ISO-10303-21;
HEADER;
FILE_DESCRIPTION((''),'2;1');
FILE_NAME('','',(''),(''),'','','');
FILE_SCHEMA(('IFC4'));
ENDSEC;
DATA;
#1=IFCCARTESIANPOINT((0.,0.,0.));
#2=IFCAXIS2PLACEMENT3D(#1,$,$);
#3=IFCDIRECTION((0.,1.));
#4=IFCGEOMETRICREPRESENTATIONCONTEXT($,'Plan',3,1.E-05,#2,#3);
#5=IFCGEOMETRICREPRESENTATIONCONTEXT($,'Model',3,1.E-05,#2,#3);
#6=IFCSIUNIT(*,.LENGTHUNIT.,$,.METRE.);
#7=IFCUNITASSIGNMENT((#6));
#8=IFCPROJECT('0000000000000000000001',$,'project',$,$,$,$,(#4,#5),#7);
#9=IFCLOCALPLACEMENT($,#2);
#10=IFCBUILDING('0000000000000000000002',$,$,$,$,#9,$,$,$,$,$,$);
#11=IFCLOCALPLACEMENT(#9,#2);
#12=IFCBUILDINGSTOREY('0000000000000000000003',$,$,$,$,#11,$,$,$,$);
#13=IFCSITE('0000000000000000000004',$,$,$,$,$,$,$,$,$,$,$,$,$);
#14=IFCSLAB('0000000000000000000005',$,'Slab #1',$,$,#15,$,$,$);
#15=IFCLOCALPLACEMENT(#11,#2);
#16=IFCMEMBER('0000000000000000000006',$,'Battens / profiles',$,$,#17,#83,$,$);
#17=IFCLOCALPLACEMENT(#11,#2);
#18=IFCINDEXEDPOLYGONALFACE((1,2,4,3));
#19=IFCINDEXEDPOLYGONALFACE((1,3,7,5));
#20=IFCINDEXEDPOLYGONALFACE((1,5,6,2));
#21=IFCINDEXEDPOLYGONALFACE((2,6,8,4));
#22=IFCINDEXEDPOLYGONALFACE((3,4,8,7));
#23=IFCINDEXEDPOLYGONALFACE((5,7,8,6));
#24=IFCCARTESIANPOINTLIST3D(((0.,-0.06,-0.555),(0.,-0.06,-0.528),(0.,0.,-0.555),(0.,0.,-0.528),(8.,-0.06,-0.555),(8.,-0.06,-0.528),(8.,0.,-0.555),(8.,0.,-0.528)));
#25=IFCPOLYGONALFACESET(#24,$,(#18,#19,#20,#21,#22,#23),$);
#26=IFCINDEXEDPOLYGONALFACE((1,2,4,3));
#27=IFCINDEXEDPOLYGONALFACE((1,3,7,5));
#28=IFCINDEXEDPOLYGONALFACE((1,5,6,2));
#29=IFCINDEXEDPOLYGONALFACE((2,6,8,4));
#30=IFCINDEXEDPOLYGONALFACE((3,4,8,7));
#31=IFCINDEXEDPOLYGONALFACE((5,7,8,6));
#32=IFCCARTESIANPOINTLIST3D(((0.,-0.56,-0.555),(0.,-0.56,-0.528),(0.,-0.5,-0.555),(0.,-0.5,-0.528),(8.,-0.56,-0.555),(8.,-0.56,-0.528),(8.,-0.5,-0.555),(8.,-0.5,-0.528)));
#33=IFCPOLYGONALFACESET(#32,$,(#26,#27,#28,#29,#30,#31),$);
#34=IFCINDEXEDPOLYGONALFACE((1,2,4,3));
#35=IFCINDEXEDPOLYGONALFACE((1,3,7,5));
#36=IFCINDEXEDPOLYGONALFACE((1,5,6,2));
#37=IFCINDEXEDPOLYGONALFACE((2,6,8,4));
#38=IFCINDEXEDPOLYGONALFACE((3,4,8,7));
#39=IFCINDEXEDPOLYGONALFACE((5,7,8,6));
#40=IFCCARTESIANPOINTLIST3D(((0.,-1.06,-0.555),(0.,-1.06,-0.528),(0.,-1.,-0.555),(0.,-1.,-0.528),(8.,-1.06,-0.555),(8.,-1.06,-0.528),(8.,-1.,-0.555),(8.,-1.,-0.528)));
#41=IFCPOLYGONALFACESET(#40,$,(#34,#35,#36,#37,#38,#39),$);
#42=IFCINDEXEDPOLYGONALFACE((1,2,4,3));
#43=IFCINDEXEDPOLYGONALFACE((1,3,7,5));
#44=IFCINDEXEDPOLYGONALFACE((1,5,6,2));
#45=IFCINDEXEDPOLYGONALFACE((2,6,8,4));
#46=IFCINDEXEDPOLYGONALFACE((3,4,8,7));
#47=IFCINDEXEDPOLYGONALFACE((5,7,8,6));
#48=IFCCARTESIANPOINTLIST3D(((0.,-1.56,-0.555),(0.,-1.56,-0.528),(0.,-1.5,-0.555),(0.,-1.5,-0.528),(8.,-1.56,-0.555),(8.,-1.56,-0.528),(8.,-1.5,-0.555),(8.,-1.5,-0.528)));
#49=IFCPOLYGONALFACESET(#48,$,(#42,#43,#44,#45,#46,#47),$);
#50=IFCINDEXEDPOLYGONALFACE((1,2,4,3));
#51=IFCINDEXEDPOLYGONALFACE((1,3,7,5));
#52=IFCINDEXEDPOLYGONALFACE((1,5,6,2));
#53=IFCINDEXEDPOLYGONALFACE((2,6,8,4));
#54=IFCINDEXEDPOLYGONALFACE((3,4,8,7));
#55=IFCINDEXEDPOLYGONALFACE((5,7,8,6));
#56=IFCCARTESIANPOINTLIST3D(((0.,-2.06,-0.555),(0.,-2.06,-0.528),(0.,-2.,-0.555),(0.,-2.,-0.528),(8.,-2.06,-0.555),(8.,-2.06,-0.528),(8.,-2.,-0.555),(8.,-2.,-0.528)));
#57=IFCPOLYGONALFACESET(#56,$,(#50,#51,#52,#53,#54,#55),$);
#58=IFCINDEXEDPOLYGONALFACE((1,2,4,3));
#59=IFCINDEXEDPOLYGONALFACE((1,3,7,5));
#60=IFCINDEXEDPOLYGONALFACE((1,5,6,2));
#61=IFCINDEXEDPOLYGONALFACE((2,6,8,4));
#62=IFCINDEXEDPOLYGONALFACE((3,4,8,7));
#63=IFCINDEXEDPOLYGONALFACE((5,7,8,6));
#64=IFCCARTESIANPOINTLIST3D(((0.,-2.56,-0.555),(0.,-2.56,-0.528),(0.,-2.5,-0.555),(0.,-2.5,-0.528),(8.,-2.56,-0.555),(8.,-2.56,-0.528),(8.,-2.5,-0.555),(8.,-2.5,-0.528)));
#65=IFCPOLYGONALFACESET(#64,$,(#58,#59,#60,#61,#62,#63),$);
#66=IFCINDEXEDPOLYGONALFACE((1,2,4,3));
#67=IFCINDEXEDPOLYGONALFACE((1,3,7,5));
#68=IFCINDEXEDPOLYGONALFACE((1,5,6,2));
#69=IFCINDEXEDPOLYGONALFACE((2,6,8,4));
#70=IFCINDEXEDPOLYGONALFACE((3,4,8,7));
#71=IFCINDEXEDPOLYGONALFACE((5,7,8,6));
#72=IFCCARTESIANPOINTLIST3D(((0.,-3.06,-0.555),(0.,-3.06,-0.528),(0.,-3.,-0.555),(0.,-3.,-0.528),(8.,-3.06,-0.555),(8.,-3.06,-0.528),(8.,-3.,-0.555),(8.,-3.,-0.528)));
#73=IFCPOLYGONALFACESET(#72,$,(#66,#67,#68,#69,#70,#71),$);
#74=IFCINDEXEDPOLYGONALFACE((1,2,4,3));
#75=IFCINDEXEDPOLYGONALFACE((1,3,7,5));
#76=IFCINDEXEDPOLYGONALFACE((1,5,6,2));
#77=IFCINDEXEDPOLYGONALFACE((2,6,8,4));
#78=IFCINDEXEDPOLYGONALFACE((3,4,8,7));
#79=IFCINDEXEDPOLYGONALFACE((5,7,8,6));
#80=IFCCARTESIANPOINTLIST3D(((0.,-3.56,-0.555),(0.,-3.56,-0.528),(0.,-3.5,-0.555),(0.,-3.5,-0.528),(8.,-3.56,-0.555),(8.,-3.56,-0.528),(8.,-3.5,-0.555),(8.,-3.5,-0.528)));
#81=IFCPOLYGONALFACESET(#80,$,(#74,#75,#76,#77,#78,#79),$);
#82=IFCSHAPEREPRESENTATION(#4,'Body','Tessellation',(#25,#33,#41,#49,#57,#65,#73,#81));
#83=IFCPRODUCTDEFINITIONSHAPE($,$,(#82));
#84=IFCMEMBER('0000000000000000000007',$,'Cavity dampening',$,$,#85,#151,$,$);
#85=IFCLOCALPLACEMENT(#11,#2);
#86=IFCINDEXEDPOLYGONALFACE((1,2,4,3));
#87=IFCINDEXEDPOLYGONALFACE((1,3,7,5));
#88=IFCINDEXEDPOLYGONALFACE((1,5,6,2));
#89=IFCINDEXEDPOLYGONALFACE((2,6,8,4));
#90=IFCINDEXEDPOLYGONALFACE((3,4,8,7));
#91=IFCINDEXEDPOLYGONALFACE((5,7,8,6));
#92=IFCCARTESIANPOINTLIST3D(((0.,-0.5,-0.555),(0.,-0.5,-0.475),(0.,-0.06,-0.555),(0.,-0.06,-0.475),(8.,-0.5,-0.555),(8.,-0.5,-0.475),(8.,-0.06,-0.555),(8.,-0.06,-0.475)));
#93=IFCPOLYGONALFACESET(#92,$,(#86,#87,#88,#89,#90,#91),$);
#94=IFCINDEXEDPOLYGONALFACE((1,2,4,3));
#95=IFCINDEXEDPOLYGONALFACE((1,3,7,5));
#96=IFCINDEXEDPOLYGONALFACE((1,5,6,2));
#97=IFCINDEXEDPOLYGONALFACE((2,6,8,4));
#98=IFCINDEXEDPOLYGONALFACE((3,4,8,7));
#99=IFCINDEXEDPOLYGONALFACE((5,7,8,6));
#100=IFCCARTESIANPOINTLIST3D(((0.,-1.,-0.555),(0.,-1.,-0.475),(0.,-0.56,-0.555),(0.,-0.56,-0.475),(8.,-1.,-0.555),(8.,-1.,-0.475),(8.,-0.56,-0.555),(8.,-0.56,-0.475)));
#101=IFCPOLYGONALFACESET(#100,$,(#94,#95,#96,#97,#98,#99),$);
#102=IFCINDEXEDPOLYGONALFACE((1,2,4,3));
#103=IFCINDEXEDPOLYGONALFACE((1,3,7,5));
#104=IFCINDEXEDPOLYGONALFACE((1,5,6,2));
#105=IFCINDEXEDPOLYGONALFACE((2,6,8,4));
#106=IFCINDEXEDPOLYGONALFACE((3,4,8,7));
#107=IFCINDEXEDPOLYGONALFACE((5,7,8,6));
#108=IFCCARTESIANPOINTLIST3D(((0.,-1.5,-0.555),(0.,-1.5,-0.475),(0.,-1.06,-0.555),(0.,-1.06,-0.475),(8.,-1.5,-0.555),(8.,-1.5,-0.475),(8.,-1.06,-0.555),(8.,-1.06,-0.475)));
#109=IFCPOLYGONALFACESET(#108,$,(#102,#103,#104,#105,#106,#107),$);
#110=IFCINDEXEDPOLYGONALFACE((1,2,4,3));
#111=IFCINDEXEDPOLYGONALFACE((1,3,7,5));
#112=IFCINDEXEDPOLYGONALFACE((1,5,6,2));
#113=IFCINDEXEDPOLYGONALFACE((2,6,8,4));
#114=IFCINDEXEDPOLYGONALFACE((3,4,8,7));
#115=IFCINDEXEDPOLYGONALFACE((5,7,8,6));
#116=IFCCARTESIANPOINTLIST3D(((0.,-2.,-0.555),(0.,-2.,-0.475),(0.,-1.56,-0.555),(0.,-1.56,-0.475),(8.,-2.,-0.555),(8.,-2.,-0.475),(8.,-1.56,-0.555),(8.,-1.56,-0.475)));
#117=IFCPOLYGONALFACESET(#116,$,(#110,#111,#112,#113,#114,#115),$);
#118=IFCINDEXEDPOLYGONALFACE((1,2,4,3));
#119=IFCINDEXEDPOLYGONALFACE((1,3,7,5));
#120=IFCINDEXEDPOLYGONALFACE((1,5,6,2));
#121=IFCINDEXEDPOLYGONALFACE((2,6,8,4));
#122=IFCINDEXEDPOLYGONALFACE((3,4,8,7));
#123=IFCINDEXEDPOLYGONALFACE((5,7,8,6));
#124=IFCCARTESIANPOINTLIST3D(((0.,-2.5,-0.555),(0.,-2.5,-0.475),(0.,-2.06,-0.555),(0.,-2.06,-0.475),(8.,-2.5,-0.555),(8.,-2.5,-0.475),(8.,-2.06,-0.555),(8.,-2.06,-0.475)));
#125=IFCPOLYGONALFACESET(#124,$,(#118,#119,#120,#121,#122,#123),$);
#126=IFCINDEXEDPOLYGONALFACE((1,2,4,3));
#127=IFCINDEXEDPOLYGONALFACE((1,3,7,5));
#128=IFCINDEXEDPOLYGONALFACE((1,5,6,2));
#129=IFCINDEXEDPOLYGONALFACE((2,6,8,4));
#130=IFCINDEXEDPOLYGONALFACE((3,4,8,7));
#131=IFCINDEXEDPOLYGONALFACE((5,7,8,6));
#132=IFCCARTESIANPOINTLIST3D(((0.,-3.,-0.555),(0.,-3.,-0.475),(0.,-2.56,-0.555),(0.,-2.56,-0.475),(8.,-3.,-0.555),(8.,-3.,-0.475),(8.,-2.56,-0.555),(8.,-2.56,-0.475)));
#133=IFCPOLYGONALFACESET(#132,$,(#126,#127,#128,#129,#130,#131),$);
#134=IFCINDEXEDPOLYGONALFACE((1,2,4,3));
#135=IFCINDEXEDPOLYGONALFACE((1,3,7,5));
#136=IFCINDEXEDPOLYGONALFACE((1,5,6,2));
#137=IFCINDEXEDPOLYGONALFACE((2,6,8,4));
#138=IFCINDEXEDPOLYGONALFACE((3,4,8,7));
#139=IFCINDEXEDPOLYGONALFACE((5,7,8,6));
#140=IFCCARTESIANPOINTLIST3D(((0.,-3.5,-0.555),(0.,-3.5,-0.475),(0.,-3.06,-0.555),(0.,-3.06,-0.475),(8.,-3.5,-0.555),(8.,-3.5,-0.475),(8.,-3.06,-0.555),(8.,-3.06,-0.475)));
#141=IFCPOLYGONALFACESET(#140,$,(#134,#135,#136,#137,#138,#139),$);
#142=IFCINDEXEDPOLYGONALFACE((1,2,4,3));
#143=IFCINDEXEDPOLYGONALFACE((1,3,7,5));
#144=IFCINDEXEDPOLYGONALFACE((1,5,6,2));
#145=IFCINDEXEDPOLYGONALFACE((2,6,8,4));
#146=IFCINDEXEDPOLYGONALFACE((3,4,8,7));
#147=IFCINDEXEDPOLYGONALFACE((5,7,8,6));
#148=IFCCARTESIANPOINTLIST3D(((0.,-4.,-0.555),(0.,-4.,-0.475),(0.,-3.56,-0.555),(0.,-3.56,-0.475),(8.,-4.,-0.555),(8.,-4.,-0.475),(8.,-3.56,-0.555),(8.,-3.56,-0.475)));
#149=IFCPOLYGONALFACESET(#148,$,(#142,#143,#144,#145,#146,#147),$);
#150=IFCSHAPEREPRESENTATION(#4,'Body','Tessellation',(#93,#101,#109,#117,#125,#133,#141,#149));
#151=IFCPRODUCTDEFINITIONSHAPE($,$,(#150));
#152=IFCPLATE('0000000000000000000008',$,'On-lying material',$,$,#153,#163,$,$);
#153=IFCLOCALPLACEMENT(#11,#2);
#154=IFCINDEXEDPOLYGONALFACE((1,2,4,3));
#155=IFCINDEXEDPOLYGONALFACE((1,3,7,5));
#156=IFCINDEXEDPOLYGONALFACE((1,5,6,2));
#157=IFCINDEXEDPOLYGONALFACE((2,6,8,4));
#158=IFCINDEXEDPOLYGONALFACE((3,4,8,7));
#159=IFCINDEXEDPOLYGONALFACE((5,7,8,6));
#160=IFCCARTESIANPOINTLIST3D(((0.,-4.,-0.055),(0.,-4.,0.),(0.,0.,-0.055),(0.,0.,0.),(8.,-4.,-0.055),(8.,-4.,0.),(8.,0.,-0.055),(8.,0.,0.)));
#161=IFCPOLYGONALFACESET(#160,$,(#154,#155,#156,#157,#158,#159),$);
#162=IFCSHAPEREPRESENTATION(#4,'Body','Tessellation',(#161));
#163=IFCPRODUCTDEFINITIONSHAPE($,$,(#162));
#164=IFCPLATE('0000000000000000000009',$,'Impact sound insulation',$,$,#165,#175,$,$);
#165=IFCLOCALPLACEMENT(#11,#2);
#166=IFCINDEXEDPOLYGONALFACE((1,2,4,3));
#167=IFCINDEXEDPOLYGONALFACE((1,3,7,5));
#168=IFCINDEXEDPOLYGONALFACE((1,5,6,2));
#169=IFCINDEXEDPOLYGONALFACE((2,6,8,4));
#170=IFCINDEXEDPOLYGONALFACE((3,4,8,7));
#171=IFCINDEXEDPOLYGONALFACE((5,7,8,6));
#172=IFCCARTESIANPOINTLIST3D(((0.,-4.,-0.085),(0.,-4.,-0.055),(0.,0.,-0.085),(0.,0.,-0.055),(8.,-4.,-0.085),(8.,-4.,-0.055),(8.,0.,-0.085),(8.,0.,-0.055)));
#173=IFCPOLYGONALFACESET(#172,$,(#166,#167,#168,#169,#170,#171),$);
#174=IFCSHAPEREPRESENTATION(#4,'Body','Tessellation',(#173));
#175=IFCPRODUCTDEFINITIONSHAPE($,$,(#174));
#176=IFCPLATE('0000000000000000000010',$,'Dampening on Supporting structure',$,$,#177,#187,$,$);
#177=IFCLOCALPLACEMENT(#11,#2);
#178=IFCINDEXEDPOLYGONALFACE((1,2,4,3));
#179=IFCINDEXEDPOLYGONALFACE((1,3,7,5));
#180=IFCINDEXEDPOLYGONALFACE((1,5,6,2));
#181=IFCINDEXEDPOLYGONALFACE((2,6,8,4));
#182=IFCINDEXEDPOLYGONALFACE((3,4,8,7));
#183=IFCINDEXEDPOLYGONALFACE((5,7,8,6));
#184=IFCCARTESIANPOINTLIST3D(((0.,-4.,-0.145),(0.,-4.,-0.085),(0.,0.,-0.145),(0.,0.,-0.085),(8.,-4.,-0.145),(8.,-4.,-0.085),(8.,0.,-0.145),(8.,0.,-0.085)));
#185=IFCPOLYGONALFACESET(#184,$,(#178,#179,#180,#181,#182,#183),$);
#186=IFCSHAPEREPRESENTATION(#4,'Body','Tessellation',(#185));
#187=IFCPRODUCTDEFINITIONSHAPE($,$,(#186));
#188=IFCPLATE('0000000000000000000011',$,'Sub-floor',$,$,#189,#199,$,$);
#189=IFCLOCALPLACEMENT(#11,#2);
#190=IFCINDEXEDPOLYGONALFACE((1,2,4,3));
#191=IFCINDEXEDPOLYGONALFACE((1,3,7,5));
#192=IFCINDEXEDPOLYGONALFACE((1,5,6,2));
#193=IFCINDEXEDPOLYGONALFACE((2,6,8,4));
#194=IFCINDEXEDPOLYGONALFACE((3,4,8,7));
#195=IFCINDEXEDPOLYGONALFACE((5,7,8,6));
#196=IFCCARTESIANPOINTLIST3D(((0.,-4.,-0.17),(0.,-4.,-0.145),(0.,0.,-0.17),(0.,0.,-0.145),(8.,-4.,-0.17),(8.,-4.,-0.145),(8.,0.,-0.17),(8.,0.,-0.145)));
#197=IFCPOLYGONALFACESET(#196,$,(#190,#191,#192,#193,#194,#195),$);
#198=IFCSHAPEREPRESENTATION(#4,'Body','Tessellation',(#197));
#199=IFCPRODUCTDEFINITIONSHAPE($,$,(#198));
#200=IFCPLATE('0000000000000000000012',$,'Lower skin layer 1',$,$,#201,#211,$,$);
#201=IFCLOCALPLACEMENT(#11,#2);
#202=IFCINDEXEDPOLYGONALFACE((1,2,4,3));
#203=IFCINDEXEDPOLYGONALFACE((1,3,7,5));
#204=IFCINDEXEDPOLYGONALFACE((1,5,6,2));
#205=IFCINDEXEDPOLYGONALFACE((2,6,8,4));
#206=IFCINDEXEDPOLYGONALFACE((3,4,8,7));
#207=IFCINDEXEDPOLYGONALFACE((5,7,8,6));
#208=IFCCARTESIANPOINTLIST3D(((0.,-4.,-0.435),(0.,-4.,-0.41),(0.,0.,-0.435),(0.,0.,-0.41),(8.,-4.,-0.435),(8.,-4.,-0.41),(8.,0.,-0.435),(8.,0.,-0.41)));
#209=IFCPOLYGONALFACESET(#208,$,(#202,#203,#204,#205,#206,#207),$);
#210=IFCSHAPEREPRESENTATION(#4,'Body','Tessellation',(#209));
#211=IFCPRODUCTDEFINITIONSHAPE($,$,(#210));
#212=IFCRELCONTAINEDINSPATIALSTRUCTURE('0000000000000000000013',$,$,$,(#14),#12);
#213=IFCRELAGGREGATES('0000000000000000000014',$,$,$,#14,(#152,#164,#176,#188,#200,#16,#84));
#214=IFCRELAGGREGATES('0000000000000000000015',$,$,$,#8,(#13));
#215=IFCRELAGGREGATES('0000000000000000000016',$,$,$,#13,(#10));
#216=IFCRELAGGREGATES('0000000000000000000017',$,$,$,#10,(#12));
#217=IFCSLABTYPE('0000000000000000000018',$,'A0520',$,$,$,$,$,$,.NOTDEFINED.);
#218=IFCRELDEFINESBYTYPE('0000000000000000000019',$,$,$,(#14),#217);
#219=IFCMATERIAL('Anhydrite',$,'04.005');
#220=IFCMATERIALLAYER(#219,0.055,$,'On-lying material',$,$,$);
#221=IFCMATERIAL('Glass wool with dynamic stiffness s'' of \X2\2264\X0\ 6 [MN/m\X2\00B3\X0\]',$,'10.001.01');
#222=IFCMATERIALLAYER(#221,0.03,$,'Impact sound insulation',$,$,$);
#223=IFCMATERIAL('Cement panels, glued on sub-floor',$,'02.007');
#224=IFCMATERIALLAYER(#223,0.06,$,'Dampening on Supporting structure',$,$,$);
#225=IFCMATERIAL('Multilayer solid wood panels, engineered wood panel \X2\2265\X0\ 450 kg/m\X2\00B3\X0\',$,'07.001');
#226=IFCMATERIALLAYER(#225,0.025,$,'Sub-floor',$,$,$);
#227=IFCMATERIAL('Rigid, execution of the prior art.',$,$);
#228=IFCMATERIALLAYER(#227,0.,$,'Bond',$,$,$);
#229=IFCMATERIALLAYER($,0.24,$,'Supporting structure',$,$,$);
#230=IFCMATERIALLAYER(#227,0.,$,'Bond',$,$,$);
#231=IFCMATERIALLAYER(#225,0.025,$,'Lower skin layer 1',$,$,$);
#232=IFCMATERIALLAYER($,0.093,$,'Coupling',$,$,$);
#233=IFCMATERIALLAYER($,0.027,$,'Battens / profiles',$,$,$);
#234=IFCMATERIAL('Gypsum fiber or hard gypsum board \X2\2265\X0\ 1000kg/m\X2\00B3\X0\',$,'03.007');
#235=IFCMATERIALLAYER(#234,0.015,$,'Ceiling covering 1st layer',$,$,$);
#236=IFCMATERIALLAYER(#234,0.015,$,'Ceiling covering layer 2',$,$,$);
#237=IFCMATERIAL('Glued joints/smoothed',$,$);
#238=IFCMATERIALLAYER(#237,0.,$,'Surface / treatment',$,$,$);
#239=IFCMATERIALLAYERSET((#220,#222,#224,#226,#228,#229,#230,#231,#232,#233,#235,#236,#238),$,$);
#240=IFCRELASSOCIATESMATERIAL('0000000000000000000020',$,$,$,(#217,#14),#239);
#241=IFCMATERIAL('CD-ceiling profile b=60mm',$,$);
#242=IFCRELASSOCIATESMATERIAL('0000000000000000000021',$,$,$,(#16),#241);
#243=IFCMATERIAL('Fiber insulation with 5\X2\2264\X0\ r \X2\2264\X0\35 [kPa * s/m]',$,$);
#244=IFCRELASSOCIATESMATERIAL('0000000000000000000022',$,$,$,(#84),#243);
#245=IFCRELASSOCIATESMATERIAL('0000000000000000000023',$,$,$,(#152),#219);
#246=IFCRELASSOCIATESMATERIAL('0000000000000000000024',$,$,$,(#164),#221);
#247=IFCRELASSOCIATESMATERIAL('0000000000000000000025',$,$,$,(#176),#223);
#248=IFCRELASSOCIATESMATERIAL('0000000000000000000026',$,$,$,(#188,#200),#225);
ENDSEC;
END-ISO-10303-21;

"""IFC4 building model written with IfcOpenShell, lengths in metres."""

from ifc_helpers import new_model, si_unit, direction, frame, frame_2d, origin, origin_with_axes, place, context, project, spatial, rectangle, extrude, material, layer, layer_set, type_object, element, aggregate, save


model = new_model("IFC4")

# Units and contexts
plan_context = context("Plan", 3, precision=1e-05, world=origin(), true_north=direction((0.0, 1.0)))
model_context = context("Model", 3, precision=1e-05, world=origin(), true_north=direction((0.0, 1.0)))
ifc_project = project(units=[si_unit("LENGTHUNIT", "METRE")], contexts=[plan_context, model_context])

# Site, building, storey
site = spatial("IfcSite", under=ifc_project)
building_placement = place(None, origin())
building = spatial("IfcBuilding", under=site, at=building_placement)
storey_placement = place(building_placement, origin())
storey = spatial("IfcBuildingStorey", under=building, at=storey_placement)

# Slab, members, plates
ifc_material_1 = material(Name="Anhydrite", Category="04.005")
ifc_layer_1 = layer(ifc_material_1, 0.055, Name="On-lying material")
ifc_material_2 = material(Name="Glass wool with dynamic stiffness s' of ≤ 6 [MN/m³]", Category="10.001.01")
ifc_layer_2 = layer(ifc_material_2, 0.03, Name="Impact sound insulation")
ifc_material_3 = material(Name="Cement panels, glued on sub-floor", Category="02.007")
ifc_layer_3 = layer(ifc_material_3, 0.06, Name="Dampening on Supporting structure")
ifc_material_4 = material(Name="Multilayer solid wood panels, engineered wood panel ≥ 450 kg/m³", Category="07.001")
ifc_layer_4 = layer(ifc_material_4, 0.025, Name="Sub-floor")
ifc_material_5 = material(Name="Rigid, execution of the prior art.")
ifc_layer_5 = layer(ifc_material_5, 0.0, Name="Bond")
ifc_layer_6 = layer(None, 0.24, Name="Supporting structure")
ifc_layer_7 = layer(ifc_material_5, 0.0, Name="Bond")
ifc_layer_8 = layer(ifc_material_4, 0.025, Name="Lower skin layer 1")
ifc_layer_9 = layer(None, 0.093, Name="Coupling")
ifc_layer_10 = layer(None, 0.027, Name="Battens / profiles")
ifc_material_6 = material(Name="Gypsum fiber or hard gypsum board ≥ 1000kg/m³", Category="03.007")
ifc_layer_11 = layer(ifc_material_6, 0.015, Name="Ceiling covering 1st layer")
ifc_layer_12 = layer(ifc_material_6, 0.015, Name="Ceiling covering layer 2")
ifc_material_7 = material(Name="Glued joints/smoothed")
ifc_layer_13 = layer(ifc_material_7, 0.0, Name="Surface / treatment")
ifc_layer_set = layer_set([ifc_layer_1, ifc_layer_2, ifc_layer_3, ifc_layer_4, ifc_layer_5, ifc_layer_6, ifc_layer_7, ifc_layer_8, ifc_layer_9, ifc_layer_10, ifc_layer_11, ifc_layer_12, ifc_layer_13])
slab_type = type_object("IfcSlabType", Name="A0520", PredefinedType="NOTDEFINED", material=ifc_layer_set)
slab_placement = place(None, frame((0.0, 0.0, 0.0), z_axis=(0.0, 0.0, -1.0), x_axis=(1.0, 0.0, 0.0)))
slab = element("IfcSlab", 1, at=slab_placement, inside=storey, type_object=slab_type, material=ifc_layer_set, Name="Slab #1")
ifc_material_8 = material(Name="Fiber insulation with 5≤ r ≤35 [kPa * s/m]")
ifc_material_9 = material(Name="CD-ceiling profile b=60mm")
member_1_placement = place(slab_placement, origin())
member_1 = element("IfcMember", 2, at=member_1_placement, material=ifc_material_9, Name="Battens / profiles", context=plan_context, shape_type="SweptSolid", body=[
    extrude(rectangle(XDim=0.06, YDim=0.027, at=frame_2d((0.03, 0.0135), x_axis=(1.0, 0.0))), frame((0.0, 0.0, 0.528), z_axis=(1.0, 0.0, 0.0), x_axis=(0.0, 1.0, 0.0)), (0.0, 0.0, 1.0), 8.0),
    extrude(rectangle(XDim=0.06, YDim=0.027, at=frame_2d((0.03, 0.0135), x_axis=(1.0, 0.0))), frame((0.0, 0.5, 0.528), z_axis=(1.0, 0.0, 0.0), x_axis=(0.0, 1.0, 0.0)), (0.0, 0.0, 1.0), 8.0),
    extrude(rectangle(XDim=0.06, YDim=0.027, at=frame_2d((0.03, 0.0135), x_axis=(1.0, 0.0))), frame((0.0, 1.0, 0.528), z_axis=(1.0, 0.0, 0.0), x_axis=(0.0, 1.0, 0.0)), (0.0, 0.0, 1.0), 8.0),
    extrude(rectangle(XDim=0.06, YDim=0.027, at=frame_2d((0.03, 0.0135), x_axis=(1.0, 0.0))), frame((0.0, 1.5, 0.528), z_axis=(1.0, 0.0, 0.0), x_axis=(0.0, 1.0, 0.0)), (0.0, 0.0, 1.0), 8.0),
    extrude(rectangle(XDim=0.06, YDim=0.027, at=frame_2d((0.03, 0.0135), x_axis=(1.0, 0.0))), frame((0.0, 2.0, 0.528), z_axis=(1.0, 0.0, 0.0), x_axis=(0.0, 1.0, 0.0)), (0.0, 0.0, 1.0), 8.0),
    extrude(rectangle(XDim=0.06, YDim=0.027, at=frame_2d((0.03, 0.0135), x_axis=(1.0, 0.0))), frame((0.0, 2.5, 0.528), z_axis=(1.0, 0.0, 0.0), x_axis=(0.0, 1.0, 0.0)), (0.0, 0.0, 1.0), 8.0),
    extrude(rectangle(XDim=0.06, YDim=0.027, at=frame_2d((0.03, 0.0135), x_axis=(1.0, 0.0))), frame((0.0, 3.0, 0.528), z_axis=(1.0, 0.0, 0.0), x_axis=(0.0, 1.0, 0.0)), (0.0, 0.0, 1.0), 8.0),
    extrude(rectangle(XDim=0.06, YDim=0.027, at=frame_2d((0.03, 0.0135), x_axis=(1.0, 0.0))), frame((0.0, 3.5, 0.528), z_axis=(1.0, 0.0, 0.0), x_axis=(0.0, 1.0, 0.0)), (0.0, 0.0, 1.0), 8.0),
])
member_2_placement = place(slab_placement, origin())
member_2 = element("IfcMember", 3, at=member_2_placement, material=ifc_material_8, Name="Cavity dampening", context=plan_context, shape_type="SweptSolid", body=[
    extrude(rectangle(XDim=0.44, YDim=0.08, at=frame_2d((0.22, 0.04), x_axis=(1.0, 0.0))), frame((0.0, 0.06, 0.475), z_axis=(1.0, 0.0, 0.0), x_axis=(0.0, 1.0, 0.0)), (0.0, 0.0, 1.0), 8.0),
    extrude(rectangle(XDim=0.44, YDim=0.08, at=frame_2d((0.22, 0.04), x_axis=(1.0, 0.0))), frame((0.0, 0.56, 0.475), z_axis=(1.0, 0.0, 0.0), x_axis=(0.0, 1.0, 0.0)), (0.0, 0.0, 1.0), 8.0),
    extrude(rectangle(XDim=0.44, YDim=0.08, at=frame_2d((0.22, 0.04), x_axis=(1.0, 0.0))), frame((0.0, 1.06, 0.475), z_axis=(1.0, 0.0, 0.0), x_axis=(0.0, 1.0, 0.0)), (0.0, 0.0, 1.0), 8.0),
    extrude(rectangle(XDim=0.44, YDim=0.08, at=frame_2d((0.22, 0.04), x_axis=(1.0, 0.0))), frame((0.0, 1.56, 0.475), z_axis=(1.0, 0.0, 0.0), x_axis=(0.0, 1.0, 0.0)), (0.0, 0.0, 1.0), 8.0),
    extrude(rectangle(XDim=0.44, YDim=0.08, at=frame_2d((0.22, 0.04), x_axis=(1.0, 0.0))), frame((0.0, 2.06, 0.475), z_axis=(1.0, 0.0, 0.0), x_axis=(0.0, 1.0, 0.0)), (0.0, 0.0, 1.0), 8.0),
    extrude(rectangle(XDim=0.44, YDim=0.08, at=frame_2d((0.22, 0.04), x_axis=(1.0, 0.0))), frame((0.0, 2.56, 0.475), z_axis=(1.0, 0.0, 0.0), x_axis=(0.0, 1.0, 0.0)), (0.0, 0.0, 1.0), 8.0),
    extrude(rectangle(XDim=0.44, YDim=0.08, at=frame_2d((0.22, 0.04), x_axis=(1.0, 0.0))), frame((0.0, 3.06, 0.475), z_axis=(1.0, 0.0, 0.0), x_axis=(0.0, 1.0, 0.0)), (0.0, 0.0, 1.0), 8.0),
    extrude(rectangle(XDim=0.44, YDim=0.08, at=frame_2d((0.22, 0.04), x_axis=(1.0, 0.0))), frame((0.0, 3.56, 0.475), z_axis=(1.0, 0.0, 0.0), x_axis=(0.0, 1.0, 0.0)), (0.0, 0.0, 1.0), 8.0),
])
plate_1_placement = place(slab_placement, origin())
plate_1 = element("IfcPlate", 4, at=plate_1_placement, material=ifc_material_1, Name="On-lying material", context=plan_context, shape_type="SweptSolid", body=[
    extrude(rectangle(XDim=8.0, YDim=4.0, at=frame_2d((4.0, 2.0), x_axis=(1.0, 0.0))), origin_with_axes(), (0.0, 0.0, 1.0), 0.055),
])
plate_2_placement = place(slab_placement, origin())
plate_2 = element("IfcPlate", 5, at=plate_2_placement, material=ifc_material_2, Name="Impact sound insulation", context=plan_context, shape_type="SweptSolid", body=[
    extrude(rectangle(XDim=8.0, YDim=4.0, at=frame_2d((4.0, 2.0), x_axis=(1.0, 0.0))), frame((0.0, 0.0, 0.055), z_axis=(0.0, 0.0, 1.0), x_axis=(1.0, 0.0, 0.0)), (0.0, 0.0, 1.0), 0.03),
])
plate_3_placement = place(slab_placement, origin())
plate_3 = element("IfcPlate", 6, at=plate_3_placement, material=ifc_material_3, Name="Dampening on Supporting structure", context=plan_context, shape_type="SweptSolid", body=[
    extrude(rectangle(XDim=8.0, YDim=4.0, at=frame_2d((4.0, 2.0), x_axis=(1.0, 0.0))), frame((0.0, 0.0, 0.085), z_axis=(0.0, 0.0, 1.0), x_axis=(1.0, 0.0, 0.0)), (0.0, 0.0, 1.0), 0.06),
])
plate_4_placement = place(slab_placement, origin())
plate_4 = element("IfcPlate", 7, at=plate_4_placement, material=ifc_material_4, Name="Sub-floor", context=plan_context, shape_type="SweptSolid", body=[
    extrude(rectangle(XDim=8.0, YDim=4.0, at=frame_2d((4.0, 2.0), x_axis=(1.0, 0.0))), frame((0.0, 0.0, 0.145), z_axis=(0.0, 0.0, 1.0), x_axis=(1.0, 0.0, 0.0)), (0.0, 0.0, 1.0), 0.025),
])
plate_5_placement = place(slab_placement, origin())
plate_5 = element("IfcPlate", 8, at=plate_5_placement, material=ifc_material_4, Name="Lower skin layer 1", context=plan_context, shape_type="SweptSolid", body=[
    extrude(rectangle(XDim=8.0, YDim=4.0, at=frame_2d((4.0, 2.0), x_axis=(1.0, 0.0))), frame((0.0, 0.0, 0.41), z_axis=(0.0, 0.0, 1.0), x_axis=(1.0, 0.0, 0.0)), (0.0, 0.0, 1.0), 0.025),
])
aggregate(slab, [plate_1, plate_2, plate_3, plate_4, plate_5, member_1, member_2])

save(model, "model.ifc")
